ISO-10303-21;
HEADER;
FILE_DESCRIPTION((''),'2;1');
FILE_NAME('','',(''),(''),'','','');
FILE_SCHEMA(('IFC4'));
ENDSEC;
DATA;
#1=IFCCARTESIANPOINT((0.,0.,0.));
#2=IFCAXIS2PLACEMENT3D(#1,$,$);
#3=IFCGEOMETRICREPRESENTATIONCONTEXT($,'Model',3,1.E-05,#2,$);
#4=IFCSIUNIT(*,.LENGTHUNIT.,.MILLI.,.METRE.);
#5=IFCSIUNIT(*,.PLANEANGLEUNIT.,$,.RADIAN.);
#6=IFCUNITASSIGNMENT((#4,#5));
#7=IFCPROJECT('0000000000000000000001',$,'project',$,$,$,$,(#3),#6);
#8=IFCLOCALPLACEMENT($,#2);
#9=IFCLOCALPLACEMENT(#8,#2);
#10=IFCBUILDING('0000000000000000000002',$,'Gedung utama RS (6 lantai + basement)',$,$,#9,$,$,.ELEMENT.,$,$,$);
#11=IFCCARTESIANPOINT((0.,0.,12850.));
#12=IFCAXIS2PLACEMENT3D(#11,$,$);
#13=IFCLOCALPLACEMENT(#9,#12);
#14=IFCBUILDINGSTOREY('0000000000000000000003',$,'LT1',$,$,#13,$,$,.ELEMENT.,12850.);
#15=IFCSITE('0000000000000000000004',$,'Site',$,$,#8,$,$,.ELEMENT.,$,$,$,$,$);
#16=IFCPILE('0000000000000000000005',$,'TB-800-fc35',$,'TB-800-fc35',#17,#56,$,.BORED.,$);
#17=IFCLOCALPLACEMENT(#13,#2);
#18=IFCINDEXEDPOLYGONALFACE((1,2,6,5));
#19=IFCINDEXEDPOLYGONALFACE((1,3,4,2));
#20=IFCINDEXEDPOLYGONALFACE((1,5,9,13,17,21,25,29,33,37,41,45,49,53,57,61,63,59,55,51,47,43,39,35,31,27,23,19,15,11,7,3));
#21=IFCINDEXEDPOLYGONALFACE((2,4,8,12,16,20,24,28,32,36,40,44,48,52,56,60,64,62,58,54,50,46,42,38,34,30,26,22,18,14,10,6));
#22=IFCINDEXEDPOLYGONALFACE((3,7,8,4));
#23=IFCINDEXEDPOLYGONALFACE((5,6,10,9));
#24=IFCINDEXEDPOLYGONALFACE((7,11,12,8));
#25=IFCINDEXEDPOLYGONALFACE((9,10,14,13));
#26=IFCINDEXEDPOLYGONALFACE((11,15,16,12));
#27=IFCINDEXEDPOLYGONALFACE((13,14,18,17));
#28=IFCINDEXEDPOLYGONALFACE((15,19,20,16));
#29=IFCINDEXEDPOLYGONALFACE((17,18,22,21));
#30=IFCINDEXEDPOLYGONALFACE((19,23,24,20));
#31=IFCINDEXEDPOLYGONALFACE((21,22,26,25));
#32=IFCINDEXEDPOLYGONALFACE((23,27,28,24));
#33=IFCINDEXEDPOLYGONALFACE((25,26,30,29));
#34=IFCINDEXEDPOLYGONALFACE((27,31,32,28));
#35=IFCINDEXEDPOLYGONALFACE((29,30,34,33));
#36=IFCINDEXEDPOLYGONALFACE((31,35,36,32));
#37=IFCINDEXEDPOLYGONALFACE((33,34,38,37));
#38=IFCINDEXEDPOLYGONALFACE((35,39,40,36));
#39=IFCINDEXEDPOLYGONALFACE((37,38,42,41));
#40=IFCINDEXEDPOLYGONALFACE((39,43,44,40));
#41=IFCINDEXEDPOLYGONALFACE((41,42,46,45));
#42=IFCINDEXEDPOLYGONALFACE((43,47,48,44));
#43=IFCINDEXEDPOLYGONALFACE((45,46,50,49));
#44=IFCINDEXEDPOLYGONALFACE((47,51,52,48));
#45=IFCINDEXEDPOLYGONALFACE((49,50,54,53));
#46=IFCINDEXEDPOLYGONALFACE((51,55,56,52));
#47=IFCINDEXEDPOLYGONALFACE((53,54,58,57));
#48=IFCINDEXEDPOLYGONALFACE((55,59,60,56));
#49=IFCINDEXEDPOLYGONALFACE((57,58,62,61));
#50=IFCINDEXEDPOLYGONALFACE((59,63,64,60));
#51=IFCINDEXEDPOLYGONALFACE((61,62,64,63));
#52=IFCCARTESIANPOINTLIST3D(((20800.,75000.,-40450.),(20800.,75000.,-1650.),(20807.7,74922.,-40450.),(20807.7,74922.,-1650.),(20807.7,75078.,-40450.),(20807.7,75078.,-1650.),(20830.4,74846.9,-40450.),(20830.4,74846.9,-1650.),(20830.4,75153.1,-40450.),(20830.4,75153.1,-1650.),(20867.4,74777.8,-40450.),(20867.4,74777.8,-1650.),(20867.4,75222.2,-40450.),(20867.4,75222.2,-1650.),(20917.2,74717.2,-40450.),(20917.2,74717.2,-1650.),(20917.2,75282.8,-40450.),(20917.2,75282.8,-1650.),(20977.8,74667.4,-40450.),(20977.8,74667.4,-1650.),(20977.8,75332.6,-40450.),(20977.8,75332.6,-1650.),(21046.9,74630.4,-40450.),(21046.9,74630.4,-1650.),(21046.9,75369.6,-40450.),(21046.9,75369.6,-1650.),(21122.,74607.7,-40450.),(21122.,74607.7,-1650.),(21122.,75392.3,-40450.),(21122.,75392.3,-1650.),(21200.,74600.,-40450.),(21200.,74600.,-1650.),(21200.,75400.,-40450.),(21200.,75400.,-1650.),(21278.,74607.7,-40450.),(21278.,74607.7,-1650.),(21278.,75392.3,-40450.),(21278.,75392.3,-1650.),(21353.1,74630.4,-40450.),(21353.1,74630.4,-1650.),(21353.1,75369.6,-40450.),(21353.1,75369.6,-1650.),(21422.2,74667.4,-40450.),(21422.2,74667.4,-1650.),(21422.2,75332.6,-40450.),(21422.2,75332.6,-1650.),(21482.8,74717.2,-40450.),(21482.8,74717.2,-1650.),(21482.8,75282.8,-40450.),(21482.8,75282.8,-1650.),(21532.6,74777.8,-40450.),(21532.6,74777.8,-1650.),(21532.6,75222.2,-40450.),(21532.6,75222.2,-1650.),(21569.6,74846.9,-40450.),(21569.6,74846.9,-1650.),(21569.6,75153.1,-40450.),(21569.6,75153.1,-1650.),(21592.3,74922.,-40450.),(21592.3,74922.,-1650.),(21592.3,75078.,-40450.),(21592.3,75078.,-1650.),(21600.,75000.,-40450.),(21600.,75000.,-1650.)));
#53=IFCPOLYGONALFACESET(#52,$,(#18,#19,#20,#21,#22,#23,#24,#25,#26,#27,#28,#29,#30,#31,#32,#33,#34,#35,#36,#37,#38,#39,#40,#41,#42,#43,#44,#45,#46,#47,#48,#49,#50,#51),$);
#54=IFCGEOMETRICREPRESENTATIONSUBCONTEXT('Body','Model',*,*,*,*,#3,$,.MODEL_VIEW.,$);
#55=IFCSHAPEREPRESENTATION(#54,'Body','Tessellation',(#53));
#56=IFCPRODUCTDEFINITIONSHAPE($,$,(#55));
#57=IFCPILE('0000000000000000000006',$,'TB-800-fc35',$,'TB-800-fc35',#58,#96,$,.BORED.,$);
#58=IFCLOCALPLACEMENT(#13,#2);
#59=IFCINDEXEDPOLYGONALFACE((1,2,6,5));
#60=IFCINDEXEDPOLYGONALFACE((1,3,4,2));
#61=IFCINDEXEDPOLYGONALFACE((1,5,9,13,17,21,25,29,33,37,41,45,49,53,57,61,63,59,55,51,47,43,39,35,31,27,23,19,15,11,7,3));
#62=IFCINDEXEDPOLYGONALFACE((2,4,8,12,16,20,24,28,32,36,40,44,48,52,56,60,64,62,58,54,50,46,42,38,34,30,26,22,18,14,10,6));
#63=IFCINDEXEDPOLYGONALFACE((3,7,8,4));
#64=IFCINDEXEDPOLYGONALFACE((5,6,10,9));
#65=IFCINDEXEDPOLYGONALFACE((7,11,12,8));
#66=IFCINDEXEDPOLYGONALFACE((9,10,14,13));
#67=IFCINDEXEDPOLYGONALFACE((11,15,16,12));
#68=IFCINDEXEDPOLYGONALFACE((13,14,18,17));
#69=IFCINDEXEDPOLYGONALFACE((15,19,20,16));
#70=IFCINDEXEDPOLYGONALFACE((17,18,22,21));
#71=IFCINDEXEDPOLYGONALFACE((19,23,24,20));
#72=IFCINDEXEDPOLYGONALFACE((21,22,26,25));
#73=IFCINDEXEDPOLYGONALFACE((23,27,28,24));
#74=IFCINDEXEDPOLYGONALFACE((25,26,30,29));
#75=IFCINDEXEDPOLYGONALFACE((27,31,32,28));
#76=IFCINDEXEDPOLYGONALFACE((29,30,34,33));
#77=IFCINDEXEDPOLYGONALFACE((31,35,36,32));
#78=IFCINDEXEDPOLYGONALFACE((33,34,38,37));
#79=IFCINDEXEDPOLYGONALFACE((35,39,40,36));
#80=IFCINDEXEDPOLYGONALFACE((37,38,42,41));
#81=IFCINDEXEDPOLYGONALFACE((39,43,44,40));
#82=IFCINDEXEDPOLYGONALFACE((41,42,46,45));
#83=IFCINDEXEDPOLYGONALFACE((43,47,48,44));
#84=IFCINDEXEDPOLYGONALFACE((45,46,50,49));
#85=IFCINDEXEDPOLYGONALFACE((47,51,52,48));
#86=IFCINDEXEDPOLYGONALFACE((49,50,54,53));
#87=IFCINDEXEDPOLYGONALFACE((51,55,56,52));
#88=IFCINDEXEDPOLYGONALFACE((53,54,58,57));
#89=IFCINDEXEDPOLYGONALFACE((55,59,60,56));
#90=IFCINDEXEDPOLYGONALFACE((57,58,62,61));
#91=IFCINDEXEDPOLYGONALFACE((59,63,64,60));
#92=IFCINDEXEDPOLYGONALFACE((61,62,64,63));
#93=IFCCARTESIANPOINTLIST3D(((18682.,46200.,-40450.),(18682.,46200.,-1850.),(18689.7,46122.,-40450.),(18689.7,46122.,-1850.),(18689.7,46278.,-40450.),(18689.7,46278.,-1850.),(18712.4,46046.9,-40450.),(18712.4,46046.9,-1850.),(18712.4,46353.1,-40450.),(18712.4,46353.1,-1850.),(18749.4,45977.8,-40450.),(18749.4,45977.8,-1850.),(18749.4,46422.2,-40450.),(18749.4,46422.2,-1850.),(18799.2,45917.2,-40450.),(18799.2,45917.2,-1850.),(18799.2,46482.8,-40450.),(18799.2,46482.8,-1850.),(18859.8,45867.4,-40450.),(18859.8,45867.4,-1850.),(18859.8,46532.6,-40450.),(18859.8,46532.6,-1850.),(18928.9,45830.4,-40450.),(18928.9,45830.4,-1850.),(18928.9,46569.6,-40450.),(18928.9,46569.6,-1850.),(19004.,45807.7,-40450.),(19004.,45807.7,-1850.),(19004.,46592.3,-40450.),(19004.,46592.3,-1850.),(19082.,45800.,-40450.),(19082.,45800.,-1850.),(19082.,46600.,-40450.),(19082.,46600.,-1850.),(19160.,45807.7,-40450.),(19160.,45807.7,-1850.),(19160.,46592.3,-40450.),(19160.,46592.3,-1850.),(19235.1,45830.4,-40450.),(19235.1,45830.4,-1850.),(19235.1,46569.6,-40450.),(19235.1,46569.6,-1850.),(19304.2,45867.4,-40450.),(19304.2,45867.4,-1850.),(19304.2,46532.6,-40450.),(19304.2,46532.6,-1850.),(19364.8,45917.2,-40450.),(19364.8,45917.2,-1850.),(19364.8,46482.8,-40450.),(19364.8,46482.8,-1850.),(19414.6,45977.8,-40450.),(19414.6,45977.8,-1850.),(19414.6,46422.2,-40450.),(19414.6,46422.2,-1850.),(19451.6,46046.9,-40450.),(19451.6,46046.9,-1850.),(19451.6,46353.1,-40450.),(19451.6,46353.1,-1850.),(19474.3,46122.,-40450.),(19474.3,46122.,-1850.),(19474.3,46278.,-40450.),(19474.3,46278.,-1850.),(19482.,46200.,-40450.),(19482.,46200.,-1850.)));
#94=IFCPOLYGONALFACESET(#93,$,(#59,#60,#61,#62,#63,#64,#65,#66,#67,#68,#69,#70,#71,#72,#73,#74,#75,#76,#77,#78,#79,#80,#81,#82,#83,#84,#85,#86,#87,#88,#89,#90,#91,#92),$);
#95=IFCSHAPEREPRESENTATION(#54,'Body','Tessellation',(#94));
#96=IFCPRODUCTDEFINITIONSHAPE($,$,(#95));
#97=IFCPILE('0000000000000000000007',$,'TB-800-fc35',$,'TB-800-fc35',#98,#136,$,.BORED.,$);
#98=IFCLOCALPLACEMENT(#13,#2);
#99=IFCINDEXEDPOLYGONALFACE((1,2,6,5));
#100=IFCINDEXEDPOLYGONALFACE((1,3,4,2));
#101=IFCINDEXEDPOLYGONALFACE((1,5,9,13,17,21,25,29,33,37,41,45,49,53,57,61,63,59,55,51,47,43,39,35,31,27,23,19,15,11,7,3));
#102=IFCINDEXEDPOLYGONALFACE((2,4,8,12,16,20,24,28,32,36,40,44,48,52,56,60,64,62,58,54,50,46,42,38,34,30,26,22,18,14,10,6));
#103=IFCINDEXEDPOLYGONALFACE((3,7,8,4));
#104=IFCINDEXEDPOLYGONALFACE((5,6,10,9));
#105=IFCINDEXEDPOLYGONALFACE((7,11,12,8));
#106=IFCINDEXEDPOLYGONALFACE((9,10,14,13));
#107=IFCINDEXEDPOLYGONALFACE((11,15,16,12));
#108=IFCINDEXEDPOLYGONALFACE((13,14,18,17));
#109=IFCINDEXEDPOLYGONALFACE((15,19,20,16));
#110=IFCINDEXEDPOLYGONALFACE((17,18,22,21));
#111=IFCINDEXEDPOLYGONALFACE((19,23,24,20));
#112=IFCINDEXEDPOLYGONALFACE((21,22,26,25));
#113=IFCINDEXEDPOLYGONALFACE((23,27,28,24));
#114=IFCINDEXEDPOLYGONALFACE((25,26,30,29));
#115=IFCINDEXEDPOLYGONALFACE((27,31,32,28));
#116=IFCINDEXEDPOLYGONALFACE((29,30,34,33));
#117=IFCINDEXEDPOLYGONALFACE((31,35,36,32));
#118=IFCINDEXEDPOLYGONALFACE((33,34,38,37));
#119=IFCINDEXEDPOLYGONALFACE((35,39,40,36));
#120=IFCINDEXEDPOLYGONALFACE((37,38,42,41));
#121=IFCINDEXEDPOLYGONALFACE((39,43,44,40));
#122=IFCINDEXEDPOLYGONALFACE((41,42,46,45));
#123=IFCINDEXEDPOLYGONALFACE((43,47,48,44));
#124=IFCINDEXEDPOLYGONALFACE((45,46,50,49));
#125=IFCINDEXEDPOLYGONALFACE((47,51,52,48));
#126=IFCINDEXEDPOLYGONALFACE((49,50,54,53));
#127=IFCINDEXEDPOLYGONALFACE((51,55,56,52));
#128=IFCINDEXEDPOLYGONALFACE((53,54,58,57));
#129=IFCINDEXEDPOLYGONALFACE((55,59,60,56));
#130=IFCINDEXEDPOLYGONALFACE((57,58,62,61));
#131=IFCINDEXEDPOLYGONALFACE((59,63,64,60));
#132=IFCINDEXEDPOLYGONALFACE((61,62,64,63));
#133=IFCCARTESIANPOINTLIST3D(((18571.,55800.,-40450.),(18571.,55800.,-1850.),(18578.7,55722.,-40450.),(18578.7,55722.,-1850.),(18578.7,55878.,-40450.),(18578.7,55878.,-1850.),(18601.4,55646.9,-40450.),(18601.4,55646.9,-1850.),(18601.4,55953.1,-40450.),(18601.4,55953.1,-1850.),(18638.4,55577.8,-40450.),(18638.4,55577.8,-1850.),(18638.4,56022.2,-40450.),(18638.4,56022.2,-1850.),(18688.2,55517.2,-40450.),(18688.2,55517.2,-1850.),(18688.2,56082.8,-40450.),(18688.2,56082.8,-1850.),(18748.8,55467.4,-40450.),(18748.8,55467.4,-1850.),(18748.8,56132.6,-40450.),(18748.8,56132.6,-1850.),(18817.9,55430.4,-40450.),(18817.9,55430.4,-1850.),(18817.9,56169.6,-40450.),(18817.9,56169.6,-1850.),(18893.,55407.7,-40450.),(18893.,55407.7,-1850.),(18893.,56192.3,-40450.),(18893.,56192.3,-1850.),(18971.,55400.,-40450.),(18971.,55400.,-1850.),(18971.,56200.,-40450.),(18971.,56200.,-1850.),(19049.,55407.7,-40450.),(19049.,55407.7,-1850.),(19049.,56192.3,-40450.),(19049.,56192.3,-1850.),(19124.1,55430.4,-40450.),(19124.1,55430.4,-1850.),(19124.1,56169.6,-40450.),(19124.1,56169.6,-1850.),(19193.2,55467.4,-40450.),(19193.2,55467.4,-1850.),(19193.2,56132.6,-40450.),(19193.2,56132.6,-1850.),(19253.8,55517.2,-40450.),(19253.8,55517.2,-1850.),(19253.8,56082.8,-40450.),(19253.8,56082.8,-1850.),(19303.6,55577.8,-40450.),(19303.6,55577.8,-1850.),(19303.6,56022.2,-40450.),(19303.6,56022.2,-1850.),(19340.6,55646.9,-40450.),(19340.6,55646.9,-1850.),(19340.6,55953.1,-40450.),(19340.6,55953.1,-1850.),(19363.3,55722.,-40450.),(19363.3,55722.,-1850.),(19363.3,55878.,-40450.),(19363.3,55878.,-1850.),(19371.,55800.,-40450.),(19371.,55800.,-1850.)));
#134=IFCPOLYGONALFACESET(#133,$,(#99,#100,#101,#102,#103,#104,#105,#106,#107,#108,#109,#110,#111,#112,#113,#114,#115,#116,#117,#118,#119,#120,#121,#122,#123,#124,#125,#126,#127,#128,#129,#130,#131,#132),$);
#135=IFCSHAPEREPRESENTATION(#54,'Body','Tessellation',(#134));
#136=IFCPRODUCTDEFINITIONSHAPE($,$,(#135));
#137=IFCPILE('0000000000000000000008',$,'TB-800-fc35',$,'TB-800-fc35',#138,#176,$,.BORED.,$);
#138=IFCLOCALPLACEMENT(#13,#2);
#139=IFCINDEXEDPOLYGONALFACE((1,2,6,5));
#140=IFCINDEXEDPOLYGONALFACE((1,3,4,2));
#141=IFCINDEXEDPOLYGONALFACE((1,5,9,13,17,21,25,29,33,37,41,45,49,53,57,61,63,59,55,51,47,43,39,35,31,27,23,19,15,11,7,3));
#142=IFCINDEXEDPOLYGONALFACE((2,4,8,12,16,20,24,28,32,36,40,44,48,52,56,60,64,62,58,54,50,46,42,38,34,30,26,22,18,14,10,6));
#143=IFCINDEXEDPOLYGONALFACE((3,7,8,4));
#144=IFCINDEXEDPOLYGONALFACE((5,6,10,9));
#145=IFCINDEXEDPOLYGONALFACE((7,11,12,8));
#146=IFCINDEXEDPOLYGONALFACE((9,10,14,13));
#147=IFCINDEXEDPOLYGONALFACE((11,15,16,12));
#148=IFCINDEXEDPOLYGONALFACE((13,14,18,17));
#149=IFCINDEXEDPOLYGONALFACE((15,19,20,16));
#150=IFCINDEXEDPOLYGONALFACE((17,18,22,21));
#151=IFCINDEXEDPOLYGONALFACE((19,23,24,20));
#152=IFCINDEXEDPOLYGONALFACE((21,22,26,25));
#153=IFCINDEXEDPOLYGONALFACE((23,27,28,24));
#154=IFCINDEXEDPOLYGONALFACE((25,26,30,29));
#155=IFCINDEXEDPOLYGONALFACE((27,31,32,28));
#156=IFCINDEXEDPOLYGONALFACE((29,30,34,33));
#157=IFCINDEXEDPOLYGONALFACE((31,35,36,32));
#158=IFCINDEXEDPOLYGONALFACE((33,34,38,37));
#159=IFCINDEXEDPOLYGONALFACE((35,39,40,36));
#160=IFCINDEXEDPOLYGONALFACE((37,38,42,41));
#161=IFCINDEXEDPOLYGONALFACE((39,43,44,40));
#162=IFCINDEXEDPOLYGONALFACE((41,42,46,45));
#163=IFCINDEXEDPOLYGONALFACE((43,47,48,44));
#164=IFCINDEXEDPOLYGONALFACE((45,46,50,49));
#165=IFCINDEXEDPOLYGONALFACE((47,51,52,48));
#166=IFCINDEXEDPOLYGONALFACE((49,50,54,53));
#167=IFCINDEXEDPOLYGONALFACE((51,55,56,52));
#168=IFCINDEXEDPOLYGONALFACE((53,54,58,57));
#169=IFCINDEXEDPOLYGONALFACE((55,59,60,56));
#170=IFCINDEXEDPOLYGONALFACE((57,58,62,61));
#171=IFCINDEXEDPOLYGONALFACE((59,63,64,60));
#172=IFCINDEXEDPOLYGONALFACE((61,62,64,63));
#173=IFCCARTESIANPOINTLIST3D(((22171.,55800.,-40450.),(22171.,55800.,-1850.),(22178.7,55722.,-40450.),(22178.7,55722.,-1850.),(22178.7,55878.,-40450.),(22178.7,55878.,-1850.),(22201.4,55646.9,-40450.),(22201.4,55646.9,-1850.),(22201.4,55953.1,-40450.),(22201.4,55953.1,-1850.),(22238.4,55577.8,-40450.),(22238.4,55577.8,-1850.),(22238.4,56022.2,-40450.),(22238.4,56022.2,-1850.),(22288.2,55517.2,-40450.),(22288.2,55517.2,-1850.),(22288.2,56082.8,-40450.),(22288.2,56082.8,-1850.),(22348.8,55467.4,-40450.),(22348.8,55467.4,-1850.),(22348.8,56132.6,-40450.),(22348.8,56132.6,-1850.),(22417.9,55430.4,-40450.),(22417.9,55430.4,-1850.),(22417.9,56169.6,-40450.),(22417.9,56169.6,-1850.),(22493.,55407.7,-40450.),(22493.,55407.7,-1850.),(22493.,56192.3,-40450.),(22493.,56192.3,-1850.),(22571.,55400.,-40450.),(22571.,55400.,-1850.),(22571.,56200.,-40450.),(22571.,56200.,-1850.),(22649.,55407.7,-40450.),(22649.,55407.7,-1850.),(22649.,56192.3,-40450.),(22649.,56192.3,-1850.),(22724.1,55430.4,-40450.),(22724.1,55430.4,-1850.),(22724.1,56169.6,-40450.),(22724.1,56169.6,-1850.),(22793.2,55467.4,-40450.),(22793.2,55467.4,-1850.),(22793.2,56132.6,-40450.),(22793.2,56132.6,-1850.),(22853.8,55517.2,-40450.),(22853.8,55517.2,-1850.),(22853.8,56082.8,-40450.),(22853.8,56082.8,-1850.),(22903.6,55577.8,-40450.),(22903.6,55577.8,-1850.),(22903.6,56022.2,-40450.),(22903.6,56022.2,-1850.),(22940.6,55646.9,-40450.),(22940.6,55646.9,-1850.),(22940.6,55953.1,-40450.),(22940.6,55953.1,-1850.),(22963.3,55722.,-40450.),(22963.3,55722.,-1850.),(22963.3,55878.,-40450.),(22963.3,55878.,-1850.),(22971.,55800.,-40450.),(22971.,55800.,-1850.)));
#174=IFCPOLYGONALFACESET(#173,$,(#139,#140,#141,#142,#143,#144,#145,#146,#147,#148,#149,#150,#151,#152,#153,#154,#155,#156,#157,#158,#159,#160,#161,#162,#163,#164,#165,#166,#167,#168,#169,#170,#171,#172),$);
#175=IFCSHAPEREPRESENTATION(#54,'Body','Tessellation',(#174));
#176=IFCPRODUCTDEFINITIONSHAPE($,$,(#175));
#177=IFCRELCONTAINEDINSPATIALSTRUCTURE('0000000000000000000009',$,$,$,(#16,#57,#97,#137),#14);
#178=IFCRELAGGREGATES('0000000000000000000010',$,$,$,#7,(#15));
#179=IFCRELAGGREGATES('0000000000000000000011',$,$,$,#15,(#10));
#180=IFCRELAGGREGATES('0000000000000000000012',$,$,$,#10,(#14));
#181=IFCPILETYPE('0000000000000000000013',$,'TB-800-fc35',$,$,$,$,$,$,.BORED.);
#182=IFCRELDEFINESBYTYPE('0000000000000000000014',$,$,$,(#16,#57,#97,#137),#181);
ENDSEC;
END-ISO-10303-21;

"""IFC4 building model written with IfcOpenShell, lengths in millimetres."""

from ifc_helpers import new_model, si_unit, frame, origin, origin_2d, place, context, subcontext, project, spatial, circle, extrude, material_profile, profile_set, profile_usage, type_object, element, save


model = new_model("IFC4")

# Units and contexts
model_context = context("Model", 3, precision=1e-05, world=origin())
body_context = subcontext(model_context, "Body", "Model", "MODEL_VIEW")
ifc_project = project(units=[si_unit("LENGTHUNIT", "METRE", prefix="MILLI"), si_unit("PLANEANGLEUNIT", "RADIAN")], contexts=[model_context])

# Site, building, storey
site_placement = place(None, origin())
site = spatial("IfcSite", under=ifc_project, at=site_placement, Name="Site", CompositionType="ELEMENT")
building_placement = place(site_placement, origin())
building = spatial("IfcBuilding", under=site, at=building_placement, Name="Gedung utama RS (6 lantai + basement)", CompositionType="ELEMENT")
storey_placement = place(building_placement, frame((0.0, 0.0, 12850.0)))
storey = spatial("IfcBuildingStorey", under=building, at=storey_placement, Name="LT1", CompositionType="ELEMENT", Elevation=12850.0)

# Piles
ifc_material_profile = material_profile(None, circle(Radius=400.0, at=origin_2d()), Name="TB-800-fc35")
ifc_profile_set = profile_set([ifc_material_profile], Name="TB-800-fc35")
ifc_profile_usage = profile_usage(ifc_profile_set, cardinal=5)
pile_type = type_object("IfcPileType", Name="TB-800-fc35", PredefinedType="BORED", material=ifc_profile_set)
for number, where, z_axis, x_axis, name in (
    (1, (21200.0, 75000.0, -40450.0), (0.0, 0.0, 1.0), (1.0, 0.0, 0.0), "TB-800-fc35"),
):
    element("IfcPile", number, at=place(storey_placement, frame(where, z_axis=z_axis, x_axis=x_axis)), inside=storey, type_object=pile_type, material=ifc_profile_usage, Name=name, ObjectType="TB-800-fc35", PredefinedType="BORED", context=body_context, shape_type="SweptSolid", body=[
        extrude(circle(Radius=400.0, at=origin_2d()), origin(), (0.0, 0.0, 1.0), 38800.0),
    ])
for number, where, z_axis, x_axis, name in (
    (2, (19082.0, 46200.0, -40450.0), (0.0, 0.0, 1.0), (1.0, 0.0, 0.0), "TB-800-fc35"),
    (3, (18971.0, 55800.0, -40450.0), (0.0, 0.0, 1.0), (1.0, 0.0, 0.0), "TB-800-fc35"),
    (4, (22571.0, 55800.0, -40450.0), (0.0, 0.0, 1.0), (1.0, 0.0, 0.0), "TB-800-fc35"),
):
    element("IfcPile", number, at=place(storey_placement, frame(where, z_axis=z_axis, x_axis=x_axis)), inside=storey, type_object=pile_type, material=ifc_profile_usage, Name=name, ObjectType="TB-800-fc35", PredefinedType="BORED", context=body_context, shape_type="SweptSolid", body=[
        extrude(circle(Radius=400.0, at=origin_2d()), origin(), (0.0, 0.0, 1.0), 38600.0),
    ])

save(model, "model.ifc")
